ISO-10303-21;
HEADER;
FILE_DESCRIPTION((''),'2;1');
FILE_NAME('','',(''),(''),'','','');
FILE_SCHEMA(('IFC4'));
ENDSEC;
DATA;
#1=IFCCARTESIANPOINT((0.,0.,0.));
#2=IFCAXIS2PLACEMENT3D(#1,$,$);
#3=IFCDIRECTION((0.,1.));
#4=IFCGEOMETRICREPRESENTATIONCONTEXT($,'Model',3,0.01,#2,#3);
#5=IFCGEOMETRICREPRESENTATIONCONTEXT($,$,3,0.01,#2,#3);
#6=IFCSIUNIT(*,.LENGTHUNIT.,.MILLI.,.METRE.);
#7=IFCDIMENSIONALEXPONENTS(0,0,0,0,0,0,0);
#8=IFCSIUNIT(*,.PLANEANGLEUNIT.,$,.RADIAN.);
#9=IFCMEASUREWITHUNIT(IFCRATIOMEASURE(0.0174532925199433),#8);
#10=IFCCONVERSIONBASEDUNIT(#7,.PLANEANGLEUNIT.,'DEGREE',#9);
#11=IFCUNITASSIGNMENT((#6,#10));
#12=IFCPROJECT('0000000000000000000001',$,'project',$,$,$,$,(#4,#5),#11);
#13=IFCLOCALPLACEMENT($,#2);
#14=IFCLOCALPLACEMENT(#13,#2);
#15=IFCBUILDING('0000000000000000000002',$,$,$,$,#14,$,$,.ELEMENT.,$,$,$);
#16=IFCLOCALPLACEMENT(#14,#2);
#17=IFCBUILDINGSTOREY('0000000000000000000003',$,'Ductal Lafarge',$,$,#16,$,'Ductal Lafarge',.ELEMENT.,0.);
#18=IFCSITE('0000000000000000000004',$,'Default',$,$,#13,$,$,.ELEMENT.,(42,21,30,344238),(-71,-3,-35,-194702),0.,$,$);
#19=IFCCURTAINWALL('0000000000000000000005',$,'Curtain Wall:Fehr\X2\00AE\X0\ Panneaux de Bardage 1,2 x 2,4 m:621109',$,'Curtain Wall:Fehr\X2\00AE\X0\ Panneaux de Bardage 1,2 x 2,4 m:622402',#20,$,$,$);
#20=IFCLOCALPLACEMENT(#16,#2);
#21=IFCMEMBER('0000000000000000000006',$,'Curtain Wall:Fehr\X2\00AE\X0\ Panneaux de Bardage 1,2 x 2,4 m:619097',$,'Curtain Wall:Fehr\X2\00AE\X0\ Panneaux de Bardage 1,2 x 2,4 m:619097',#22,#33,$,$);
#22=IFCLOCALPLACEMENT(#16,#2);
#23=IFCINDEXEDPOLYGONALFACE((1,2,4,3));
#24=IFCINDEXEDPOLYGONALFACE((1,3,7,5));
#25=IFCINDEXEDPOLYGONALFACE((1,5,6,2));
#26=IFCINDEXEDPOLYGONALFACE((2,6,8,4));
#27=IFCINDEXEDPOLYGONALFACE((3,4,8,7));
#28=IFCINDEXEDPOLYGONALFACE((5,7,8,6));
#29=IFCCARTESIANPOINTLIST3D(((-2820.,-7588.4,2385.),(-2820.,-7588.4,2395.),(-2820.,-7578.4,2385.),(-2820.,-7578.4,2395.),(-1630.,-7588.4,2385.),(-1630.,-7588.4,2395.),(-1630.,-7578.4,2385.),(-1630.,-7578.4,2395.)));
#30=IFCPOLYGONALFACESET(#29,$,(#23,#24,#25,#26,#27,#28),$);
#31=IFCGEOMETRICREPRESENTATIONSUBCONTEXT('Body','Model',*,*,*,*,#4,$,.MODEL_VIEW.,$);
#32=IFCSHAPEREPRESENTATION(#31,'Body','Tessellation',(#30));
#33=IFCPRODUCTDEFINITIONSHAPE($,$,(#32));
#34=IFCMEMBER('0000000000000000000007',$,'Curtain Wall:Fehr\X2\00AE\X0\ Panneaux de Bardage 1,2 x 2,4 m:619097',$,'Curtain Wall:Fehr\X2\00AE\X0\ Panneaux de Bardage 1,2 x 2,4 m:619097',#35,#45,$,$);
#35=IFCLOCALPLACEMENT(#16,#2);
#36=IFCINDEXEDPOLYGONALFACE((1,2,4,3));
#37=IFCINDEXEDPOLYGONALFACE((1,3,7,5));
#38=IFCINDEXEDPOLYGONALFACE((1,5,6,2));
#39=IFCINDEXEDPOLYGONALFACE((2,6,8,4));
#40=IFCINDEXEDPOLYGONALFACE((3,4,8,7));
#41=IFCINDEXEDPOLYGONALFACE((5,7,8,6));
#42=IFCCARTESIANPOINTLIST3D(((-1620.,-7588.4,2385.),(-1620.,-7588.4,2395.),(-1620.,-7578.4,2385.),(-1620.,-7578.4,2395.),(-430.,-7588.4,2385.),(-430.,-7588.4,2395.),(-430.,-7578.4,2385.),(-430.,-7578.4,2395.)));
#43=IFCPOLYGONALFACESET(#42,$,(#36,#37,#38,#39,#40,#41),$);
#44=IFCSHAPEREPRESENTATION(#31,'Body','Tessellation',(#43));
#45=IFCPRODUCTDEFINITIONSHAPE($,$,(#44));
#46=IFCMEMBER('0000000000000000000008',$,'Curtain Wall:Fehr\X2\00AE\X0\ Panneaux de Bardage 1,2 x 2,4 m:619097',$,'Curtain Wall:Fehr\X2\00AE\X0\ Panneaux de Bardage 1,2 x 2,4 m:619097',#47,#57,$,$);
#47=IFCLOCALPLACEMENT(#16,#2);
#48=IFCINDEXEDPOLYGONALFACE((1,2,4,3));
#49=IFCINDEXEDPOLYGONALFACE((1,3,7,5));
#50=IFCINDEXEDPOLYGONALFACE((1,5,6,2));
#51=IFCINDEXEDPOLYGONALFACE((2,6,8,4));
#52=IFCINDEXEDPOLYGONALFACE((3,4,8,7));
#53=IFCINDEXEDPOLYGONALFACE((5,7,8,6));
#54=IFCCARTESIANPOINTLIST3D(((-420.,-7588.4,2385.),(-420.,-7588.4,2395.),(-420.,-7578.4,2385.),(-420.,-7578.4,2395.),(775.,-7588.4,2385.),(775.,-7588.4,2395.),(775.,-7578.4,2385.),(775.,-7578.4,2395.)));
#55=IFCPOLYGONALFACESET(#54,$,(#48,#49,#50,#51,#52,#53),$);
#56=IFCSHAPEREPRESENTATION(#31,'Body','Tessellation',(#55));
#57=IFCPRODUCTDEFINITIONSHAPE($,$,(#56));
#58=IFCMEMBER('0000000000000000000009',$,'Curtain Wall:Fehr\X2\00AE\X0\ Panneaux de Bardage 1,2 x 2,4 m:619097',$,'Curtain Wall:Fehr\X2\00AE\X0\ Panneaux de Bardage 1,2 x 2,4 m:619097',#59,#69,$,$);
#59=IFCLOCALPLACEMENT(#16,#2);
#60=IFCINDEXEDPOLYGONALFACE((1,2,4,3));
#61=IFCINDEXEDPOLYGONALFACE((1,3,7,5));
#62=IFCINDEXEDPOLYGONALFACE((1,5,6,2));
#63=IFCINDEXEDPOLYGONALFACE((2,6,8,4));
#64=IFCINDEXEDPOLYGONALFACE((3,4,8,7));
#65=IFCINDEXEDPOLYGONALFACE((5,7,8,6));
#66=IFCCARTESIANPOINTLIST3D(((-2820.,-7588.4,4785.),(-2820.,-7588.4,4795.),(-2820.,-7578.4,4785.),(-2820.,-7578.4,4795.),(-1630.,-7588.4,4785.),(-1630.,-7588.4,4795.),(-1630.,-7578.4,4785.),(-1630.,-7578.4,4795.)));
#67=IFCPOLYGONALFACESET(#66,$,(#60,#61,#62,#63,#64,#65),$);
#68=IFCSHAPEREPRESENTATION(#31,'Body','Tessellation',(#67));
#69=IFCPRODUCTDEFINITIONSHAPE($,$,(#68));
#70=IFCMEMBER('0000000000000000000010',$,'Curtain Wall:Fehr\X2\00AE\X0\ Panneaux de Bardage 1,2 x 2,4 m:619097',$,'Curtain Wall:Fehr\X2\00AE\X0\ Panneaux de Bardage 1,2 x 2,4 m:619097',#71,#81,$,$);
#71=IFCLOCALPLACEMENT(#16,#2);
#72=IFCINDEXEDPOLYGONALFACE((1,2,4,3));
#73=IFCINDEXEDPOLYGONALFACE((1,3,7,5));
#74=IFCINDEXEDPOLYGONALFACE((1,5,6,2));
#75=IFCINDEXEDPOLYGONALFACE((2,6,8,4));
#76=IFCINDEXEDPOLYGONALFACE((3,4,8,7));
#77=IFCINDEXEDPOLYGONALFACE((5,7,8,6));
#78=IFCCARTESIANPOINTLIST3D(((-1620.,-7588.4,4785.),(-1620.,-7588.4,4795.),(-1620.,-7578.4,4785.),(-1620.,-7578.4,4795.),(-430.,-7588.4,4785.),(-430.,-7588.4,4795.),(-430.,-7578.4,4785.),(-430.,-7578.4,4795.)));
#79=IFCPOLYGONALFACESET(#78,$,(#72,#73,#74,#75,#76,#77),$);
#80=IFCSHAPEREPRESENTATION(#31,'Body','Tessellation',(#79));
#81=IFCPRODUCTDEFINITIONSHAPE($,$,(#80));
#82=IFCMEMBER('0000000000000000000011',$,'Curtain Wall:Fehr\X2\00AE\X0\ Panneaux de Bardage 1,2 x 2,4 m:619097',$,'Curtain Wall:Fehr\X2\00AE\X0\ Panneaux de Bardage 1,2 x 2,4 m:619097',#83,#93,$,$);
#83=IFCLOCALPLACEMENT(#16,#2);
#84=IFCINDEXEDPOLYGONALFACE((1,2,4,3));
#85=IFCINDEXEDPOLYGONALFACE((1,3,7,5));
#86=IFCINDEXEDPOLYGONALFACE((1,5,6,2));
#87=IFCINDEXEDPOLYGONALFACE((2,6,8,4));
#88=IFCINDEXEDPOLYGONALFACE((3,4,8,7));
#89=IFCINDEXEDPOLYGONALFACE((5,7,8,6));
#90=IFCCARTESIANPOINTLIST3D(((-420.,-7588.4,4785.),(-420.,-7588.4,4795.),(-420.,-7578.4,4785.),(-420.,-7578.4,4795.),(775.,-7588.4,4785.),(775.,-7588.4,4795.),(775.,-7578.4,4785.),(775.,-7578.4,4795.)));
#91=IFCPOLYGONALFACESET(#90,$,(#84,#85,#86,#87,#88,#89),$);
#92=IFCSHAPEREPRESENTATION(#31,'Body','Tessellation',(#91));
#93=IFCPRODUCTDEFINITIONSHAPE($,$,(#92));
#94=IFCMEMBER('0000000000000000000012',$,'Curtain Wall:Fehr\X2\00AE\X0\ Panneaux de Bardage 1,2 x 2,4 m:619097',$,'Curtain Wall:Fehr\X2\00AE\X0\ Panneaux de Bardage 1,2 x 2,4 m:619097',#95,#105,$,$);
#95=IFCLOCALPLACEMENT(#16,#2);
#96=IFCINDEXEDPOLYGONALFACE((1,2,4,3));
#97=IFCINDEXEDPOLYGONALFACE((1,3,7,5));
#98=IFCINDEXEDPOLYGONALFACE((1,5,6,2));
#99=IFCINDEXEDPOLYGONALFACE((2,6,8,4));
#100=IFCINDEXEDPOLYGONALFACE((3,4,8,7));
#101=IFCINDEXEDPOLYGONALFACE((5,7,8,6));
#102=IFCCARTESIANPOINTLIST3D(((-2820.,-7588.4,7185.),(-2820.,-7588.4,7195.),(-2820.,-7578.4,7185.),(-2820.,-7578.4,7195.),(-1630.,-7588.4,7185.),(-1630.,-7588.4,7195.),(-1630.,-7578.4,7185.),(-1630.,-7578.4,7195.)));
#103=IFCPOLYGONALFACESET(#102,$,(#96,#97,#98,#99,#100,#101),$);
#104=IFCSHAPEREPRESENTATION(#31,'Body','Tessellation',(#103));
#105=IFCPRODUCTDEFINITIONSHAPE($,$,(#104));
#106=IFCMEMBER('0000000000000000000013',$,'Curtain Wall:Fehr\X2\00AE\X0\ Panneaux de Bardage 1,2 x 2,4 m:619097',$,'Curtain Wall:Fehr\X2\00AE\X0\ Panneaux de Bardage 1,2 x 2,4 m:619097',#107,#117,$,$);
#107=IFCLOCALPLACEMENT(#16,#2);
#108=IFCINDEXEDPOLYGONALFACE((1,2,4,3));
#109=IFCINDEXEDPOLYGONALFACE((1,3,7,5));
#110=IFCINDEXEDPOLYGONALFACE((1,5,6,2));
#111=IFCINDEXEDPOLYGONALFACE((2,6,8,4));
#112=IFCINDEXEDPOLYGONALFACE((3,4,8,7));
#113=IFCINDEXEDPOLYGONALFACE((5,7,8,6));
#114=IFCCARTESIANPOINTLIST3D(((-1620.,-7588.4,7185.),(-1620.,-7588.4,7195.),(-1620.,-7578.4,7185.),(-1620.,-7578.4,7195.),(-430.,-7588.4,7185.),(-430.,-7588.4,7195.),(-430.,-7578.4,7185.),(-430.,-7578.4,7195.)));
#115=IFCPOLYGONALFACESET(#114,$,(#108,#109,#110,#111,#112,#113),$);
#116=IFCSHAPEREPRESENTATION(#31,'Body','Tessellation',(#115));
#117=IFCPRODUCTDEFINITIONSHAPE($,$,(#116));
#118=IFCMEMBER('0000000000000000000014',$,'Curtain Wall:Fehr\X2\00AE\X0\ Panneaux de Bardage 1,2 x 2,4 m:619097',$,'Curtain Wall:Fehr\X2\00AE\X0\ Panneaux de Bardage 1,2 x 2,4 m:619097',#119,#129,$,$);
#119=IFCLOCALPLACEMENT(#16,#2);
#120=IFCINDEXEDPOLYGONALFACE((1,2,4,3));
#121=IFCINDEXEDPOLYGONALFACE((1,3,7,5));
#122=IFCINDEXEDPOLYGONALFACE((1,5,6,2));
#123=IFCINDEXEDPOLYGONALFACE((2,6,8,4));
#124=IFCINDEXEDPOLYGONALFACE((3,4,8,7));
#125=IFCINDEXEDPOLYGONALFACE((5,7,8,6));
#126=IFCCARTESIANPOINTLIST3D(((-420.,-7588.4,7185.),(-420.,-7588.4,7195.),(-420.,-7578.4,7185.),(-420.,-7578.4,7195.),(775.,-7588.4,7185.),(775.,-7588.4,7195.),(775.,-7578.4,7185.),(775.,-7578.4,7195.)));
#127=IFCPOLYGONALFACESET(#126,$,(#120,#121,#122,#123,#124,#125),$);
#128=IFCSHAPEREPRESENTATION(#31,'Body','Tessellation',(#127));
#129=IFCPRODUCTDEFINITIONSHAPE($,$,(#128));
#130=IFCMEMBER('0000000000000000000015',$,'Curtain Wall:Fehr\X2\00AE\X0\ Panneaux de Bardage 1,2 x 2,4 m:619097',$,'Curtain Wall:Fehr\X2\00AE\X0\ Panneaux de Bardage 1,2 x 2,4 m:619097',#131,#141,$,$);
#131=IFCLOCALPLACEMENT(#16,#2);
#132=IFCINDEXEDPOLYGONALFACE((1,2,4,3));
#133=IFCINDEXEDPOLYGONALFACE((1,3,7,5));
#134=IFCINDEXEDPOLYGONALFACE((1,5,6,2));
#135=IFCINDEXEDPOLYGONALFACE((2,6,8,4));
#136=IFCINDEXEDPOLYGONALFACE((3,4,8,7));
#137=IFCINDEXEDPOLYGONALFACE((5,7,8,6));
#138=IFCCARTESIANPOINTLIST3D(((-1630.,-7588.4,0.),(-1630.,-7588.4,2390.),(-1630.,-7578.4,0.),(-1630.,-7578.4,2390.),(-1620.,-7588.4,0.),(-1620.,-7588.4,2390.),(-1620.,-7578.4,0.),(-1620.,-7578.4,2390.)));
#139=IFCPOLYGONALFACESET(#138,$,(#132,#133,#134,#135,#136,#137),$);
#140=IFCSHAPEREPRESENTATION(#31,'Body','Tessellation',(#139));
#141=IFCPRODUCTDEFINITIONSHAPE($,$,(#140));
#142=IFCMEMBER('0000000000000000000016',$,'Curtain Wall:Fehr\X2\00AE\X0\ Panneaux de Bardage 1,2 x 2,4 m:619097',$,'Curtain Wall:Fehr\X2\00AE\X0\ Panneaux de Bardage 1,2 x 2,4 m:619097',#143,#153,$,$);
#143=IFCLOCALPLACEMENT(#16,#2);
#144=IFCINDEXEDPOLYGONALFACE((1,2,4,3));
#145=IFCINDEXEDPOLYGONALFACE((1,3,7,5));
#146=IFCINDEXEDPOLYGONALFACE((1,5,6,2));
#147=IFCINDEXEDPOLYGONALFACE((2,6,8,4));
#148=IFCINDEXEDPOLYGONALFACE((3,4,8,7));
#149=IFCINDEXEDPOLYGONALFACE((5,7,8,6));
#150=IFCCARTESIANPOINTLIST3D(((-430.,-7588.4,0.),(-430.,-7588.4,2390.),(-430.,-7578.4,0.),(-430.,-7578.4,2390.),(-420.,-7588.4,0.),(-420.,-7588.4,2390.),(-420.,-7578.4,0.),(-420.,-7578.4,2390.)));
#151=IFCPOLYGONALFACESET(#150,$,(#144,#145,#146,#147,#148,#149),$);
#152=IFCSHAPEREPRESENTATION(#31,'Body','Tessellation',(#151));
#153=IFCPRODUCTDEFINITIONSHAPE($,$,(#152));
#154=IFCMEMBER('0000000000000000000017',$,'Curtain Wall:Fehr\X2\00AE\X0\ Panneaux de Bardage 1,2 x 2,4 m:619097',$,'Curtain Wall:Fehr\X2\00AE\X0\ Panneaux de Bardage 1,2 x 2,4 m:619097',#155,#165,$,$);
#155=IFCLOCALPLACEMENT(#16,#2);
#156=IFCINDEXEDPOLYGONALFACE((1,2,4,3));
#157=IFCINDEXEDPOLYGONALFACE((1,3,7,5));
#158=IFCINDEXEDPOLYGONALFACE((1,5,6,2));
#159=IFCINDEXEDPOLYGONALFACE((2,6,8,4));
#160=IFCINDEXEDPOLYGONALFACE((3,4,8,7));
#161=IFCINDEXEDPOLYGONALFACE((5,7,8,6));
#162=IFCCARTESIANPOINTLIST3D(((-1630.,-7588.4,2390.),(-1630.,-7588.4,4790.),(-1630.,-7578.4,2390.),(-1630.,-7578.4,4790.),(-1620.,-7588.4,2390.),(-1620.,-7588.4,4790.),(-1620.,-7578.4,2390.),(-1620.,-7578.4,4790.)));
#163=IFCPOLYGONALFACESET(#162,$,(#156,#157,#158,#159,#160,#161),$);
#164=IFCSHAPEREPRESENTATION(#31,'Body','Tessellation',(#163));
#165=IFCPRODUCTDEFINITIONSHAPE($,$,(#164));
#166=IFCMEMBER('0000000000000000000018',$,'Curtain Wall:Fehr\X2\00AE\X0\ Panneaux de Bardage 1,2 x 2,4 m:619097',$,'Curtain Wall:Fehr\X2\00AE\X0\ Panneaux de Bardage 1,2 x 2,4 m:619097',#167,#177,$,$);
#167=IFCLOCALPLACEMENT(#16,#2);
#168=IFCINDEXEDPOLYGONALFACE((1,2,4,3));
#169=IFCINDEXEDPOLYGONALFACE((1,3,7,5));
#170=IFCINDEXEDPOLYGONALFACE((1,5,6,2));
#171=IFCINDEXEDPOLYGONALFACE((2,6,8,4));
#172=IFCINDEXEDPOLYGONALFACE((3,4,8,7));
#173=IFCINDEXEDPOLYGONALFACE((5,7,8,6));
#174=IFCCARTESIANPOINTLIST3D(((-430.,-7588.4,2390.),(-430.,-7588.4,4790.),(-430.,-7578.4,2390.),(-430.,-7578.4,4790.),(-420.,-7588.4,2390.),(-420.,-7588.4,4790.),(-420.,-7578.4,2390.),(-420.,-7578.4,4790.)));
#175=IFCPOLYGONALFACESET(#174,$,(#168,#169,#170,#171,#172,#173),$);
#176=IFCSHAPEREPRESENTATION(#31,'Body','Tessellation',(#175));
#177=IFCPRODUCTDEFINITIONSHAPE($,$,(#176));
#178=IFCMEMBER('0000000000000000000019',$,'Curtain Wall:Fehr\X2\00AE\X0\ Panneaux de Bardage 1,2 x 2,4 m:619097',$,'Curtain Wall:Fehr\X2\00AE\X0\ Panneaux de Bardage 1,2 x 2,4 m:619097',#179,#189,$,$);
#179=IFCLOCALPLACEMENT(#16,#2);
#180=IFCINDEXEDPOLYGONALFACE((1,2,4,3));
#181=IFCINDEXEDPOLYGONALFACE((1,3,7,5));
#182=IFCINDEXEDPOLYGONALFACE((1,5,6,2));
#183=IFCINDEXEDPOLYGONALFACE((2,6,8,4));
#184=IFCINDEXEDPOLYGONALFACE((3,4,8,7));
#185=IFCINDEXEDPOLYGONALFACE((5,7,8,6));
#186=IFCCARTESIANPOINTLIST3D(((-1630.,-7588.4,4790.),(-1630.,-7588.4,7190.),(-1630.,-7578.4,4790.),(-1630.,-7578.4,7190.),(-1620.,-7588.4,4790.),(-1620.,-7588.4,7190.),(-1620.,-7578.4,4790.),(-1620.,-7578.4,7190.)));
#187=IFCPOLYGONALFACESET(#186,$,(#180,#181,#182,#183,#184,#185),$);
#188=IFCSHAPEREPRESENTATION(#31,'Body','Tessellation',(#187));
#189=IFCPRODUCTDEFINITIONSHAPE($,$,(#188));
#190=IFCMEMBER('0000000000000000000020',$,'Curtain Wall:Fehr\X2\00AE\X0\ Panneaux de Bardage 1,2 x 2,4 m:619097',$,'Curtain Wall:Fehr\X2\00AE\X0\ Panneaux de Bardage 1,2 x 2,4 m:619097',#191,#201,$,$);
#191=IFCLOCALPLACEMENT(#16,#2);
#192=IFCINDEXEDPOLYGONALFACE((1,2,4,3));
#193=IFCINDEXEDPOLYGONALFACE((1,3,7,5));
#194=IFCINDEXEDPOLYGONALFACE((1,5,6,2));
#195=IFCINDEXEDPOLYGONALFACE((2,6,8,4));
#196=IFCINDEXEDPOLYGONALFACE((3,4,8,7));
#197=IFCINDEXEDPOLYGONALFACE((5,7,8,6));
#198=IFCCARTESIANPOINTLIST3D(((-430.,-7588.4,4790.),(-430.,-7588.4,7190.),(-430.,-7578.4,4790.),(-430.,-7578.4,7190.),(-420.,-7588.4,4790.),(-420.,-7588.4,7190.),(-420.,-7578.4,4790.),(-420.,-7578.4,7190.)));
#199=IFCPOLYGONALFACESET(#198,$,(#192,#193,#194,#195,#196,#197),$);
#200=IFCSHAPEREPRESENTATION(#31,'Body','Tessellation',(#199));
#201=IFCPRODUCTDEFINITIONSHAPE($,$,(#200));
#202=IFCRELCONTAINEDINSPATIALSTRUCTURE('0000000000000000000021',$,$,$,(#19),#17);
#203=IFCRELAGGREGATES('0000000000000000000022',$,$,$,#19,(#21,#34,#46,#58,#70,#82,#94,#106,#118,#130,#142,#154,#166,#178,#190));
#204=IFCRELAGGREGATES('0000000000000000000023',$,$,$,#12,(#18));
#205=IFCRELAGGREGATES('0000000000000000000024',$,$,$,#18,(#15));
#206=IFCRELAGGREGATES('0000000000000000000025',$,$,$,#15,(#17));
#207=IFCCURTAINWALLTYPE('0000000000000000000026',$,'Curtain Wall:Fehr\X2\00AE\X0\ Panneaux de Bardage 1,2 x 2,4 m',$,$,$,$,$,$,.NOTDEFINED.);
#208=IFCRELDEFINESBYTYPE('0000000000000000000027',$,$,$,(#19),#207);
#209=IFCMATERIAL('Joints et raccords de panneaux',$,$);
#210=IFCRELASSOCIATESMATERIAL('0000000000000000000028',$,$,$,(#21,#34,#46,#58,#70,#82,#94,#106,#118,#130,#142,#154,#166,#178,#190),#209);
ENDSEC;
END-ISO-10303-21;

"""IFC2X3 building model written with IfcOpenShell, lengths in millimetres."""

from ifc_helpers import new_model, entity, si_unit, converted_unit, direction, frame, frame_2d, origin, origin_2d_with_axis, place, context, subcontext, project, spatial, rectangle, extrude, material, type_object, element, aggregate, save


model = new_model("IFC2X3")

# Units and contexts
model_context = context("Model", 3, precision=0.01, world=origin(), true_north=direction((0.0, 1.0)))
context_of_model = context(None, 3, precision=0.01, world=origin(), true_north=direction((0.0, 1.0)))
body_context = subcontext(model_context, "Body", "Model", "MODEL_VIEW")
ifc_project = project(units=[si_unit("LENGTHUNIT", "METRE", prefix="MILLI"), converted_unit("PLANEANGLEUNIT", "DEGREE", entity("IfcRatioMeasure", 0.0174532925199433), si_unit("PLANEANGLEUNIT", "RADIAN"), dimensions=[0, 0, 0, 0, 0, 0, 0])], contexts=[model_context, context_of_model])

# Site, building, storey
site_placement = place(None, origin())
site = spatial("IfcSite", under=ifc_project, at=site_placement, Name="Default", CompositionType="ELEMENT", RefLatitude=(42, 21, 30, 344238), RefLongitude=(-71, -3, -35, -194702), RefElevation=0.0)
building_placement = place(site_placement, origin())
building = spatial("IfcBuilding", under=site, at=building_placement, CompositionType="ELEMENT")
storey_placement = place(building_placement, origin())
storey = spatial("IfcBuildingStorey", under=building, at=storey_placement, Name="Ductal Lafarge", LongName="Ductal Lafarge", CompositionType="ELEMENT", Elevation=0.0)

# Curtain wall, members
curtain_wall_type_1 = type_object("IfcCurtainWallType", Name="Curtain Wall:Fehr® Panneaux de Bardage 1,2 x 2,4 m", PredefinedType="NOTDEFINED")
curtain_wall_1_placement = place(storey_placement, origin())
curtain_wall_1 = element("IfcCurtainWall", 1, at=curtain_wall_1_placement, inside=storey, type_object=curtain_wall_type_1, Name="Curtain Wall:Fehr® Panneaux de Bardage 1,2 x 2,4 m:621109", ObjectType="Curtain Wall:Fehr® Panneaux de Bardage 1,2 x 2,4 m:622402")
ifc_material_1 = material(Name="Joints et raccords de panneaux")
member_1_placement = place(curtain_wall_1_placement, frame((-2820.0, -7588.4, 2385.0)))
member_1 = element("IfcMember", 2, at=member_1_placement, material=ifc_material_1, Name="Curtain Wall:Fehr® Panneaux de Bardage 1,2 x 2,4 m:619097", ObjectType="Curtain Wall:Fehr® Panneaux de Bardage 1,2 x 2,4 m:619097", context=body_context, shape_type="SweptSolid", body=[
    extrude(rectangle(XDim=1190.0, YDim=10.0, at=frame_2d((0.0, 0.0), x_axis=(1.0, 0.0))), frame((595.0, 5.0, 0.0), z_axis=(0.0, 0.0, 1.0), x_axis=(-1.0, 0.0, 0.0)), (0.0, 0.0, 1.0), 10.0),
])
member_2_placement = place(curtain_wall_1_placement, frame((-1620.0, -7588.4, 2385.0)))
member_2 = element("IfcMember", 3, at=member_2_placement, material=ifc_material_1, Name="Curtain Wall:Fehr® Panneaux de Bardage 1,2 x 2,4 m:619097", ObjectType="Curtain Wall:Fehr® Panneaux de Bardage 1,2 x 2,4 m:619097", context=body_context, shape_type="SweptSolid", body=[
    extrude(rectangle(XDim=1190.0, YDim=10.0, at=frame_2d((0.0, 0.0), x_axis=(1.0, 0.0))), frame((595.0, 5.0, 0.0), z_axis=(0.0, 0.0, 1.0), x_axis=(-1.0, 0.0, 0.0)), (0.0, 0.0, 1.0), 10.0),
])
member_3_placement = place(curtain_wall_1_placement, frame((-420.0, -7588.4, 2385.0)))
member_3 = element("IfcMember", 4, at=member_3_placement, material=ifc_material_1, Name="Curtain Wall:Fehr® Panneaux de Bardage 1,2 x 2,4 m:619097", ObjectType="Curtain Wall:Fehr® Panneaux de Bardage 1,2 x 2,4 m:619097", context=body_context, shape_type="SweptSolid", body=[
    extrude(rectangle(XDim=1195.0, YDim=10.0, at=frame_2d((0.0, 0.0), x_axis=(1.0, 0.0))), frame((597.5, 5.0, 0.0), z_axis=(0.0, 0.0, 1.0), x_axis=(-1.0, 0.0, 0.0)), (0.0, 0.0, 1.0), 10.0),
])
member_4_placement = place(curtain_wall_1_placement, frame((-2820.0, -7588.4, 4785.0)))
member_4 = element("IfcMember", 5, at=member_4_placement, material=ifc_material_1, Name="Curtain Wall:Fehr® Panneaux de Bardage 1,2 x 2,4 m:619097", ObjectType="Curtain Wall:Fehr® Panneaux de Bardage 1,2 x 2,4 m:619097", context=body_context, shape_type="SweptSolid", body=[
    extrude(rectangle(XDim=1190.0, YDim=10.0, at=frame_2d((0.0, 0.0), x_axis=(1.0, 0.0))), frame((595.0, 5.0, 0.0), z_axis=(0.0, 0.0, 1.0), x_axis=(-1.0, 0.0, 0.0)), (0.0, 0.0, 1.0), 10.0),
])
member_5_placement = place(curtain_wall_1_placement, frame((-1620.0, -7588.4, 4785.0)))
member_5 = element("IfcMember", 6, at=member_5_placement, material=ifc_material_1, Name="Curtain Wall:Fehr® Panneaux de Bardage 1,2 x 2,4 m:619097", ObjectType="Curtain Wall:Fehr® Panneaux de Bardage 1,2 x 2,4 m:619097", context=body_context, shape_type="SweptSolid", body=[
    extrude(rectangle(XDim=1190.0, YDim=10.0, at=frame_2d((0.0, 0.0), x_axis=(1.0, 0.0))), frame((595.0, 5.0, 0.0), z_axis=(0.0, 0.0, 1.0), x_axis=(-1.0, 0.0, 0.0)), (0.0, 0.0, 1.0), 10.0),
])
member_6_placement = place(curtain_wall_1_placement, frame((-420.0, -7588.4, 4785.0)))
member_6 = element("IfcMember", 7, at=member_6_placement, material=ifc_material_1, Name="Curtain Wall:Fehr® Panneaux de Bardage 1,2 x 2,4 m:619097", ObjectType="Curtain Wall:Fehr® Panneaux de Bardage 1,2 x 2,4 m:619097", context=body_context, shape_type="SweptSolid", body=[
    extrude(rectangle(XDim=1195.0, YDim=10.0, at=frame_2d((0.0, 0.0), x_axis=(1.0, 0.0))), frame((597.5, 5.0, 0.0), z_axis=(0.0, 0.0, 1.0), x_axis=(-1.0, 0.0, 0.0)), (0.0, 0.0, 1.0), 10.0),
])
member_7_placement = place(curtain_wall_1_placement, frame((-2820.0, -7588.4, 7185.0)))
member_7 = element("IfcMember", 8, at=member_7_placement, material=ifc_material_1, Name="Curtain Wall:Fehr® Panneaux de Bardage 1,2 x 2,4 m:619097", ObjectType="Curtain Wall:Fehr® Panneaux de Bardage 1,2 x 2,4 m:619097", context=body_context, shape_type="SweptSolid", body=[
    extrude(rectangle(XDim=1190.0, YDim=10.0, at=frame_2d((0.0, 0.0), x_axis=(1.0, 0.0))), frame((595.0, 5.0, 0.0), z_axis=(0.0, 0.0, 1.0), x_axis=(-1.0, 0.0, 0.0)), (0.0, 0.0, 1.0), 10.0),
])
member_8_placement = place(curtain_wall_1_placement, frame((-1620.0, -7588.4, 7185.0)))
member_8 = element("IfcMember", 9, at=member_8_placement, material=ifc_material_1, Name="Curtain Wall:Fehr® Panneaux de Bardage 1,2 x 2,4 m:619097", ObjectType="Curtain Wall:Fehr® Panneaux de Bardage 1,2 x 2,4 m:619097", context=body_context, shape_type="SweptSolid", body=[
    extrude(rectangle(XDim=1190.0, YDim=10.0, at=frame_2d((0.0, 0.0), x_axis=(1.0, 0.0))), frame((595.0, 5.0, 0.0), z_axis=(0.0, 0.0, 1.0), x_axis=(-1.0, 0.0, 0.0)), (0.0, 0.0, 1.0), 10.0),
])
member_9_placement = place(curtain_wall_1_placement, frame((-420.0, -7588.4, 7185.0)))
member_9 = element("IfcMember", 10, at=member_9_placement, material=ifc_material_1, Name="Curtain Wall:Fehr® Panneaux de Bardage 1,2 x 2,4 m:619097", ObjectType="Curtain Wall:Fehr® Panneaux de Bardage 1,2 x 2,4 m:619097", context=body_context, shape_type="SweptSolid", body=[
    extrude(rectangle(XDim=1195.0, YDim=10.0, at=frame_2d((0.0, 0.0), x_axis=(1.0, 0.0))), frame((597.5, 5.0, 0.0), z_axis=(0.0, 0.0, 1.0), x_axis=(-1.0, 0.0, 0.0)), (0.0, 0.0, 1.0), 10.0),
])
member_10_placement = place(curtain_wall_1_placement, frame((-1630.0, -7588.4, 0.0)))
member_10 = element("IfcMember", 11, at=member_10_placement, material=ifc_material_1, Name="Curtain Wall:Fehr® Panneaux de Bardage 1,2 x 2,4 m:619097", ObjectType="Curtain Wall:Fehr® Panneaux de Bardage 1,2 x 2,4 m:619097", context=body_context, shape_type="SweptSolid", body=[
    extrude(rectangle(XDim=10.0, YDim=10.0, at=origin_2d_with_axis()), frame((5.0, 5.0, 0.0), z_axis=(0.0, 0.0, 1.0), x_axis=(0.0, 1.0, 0.0)), (0.0, 0.0, 1.0), 2390.0),
])
member_11_placement = place(curtain_wall_1_placement, frame((-430.0, -7588.4, 0.0)))
member_11 = element("IfcMember", 12, at=member_11_placement, material=ifc_material_1, Name="Curtain Wall:Fehr® Panneaux de Bardage 1,2 x 2,4 m:619097", ObjectType="Curtain Wall:Fehr® Panneaux de Bardage 1,2 x 2,4 m:619097", context=body_context, shape_type="SweptSolid", body=[
    extrude(rectangle(XDim=10.0, YDim=10.0, at=origin_2d_with_axis()), frame((5.0, 5.0, 0.0), z_axis=(0.0, 0.0, 1.0), x_axis=(0.0, 1.0, 0.0)), (0.0, 0.0, 1.0), 2390.0),
])
member_12_placement = place(curtain_wall_1_placement, frame((-1630.0, -7588.4, 2390.0)))
member_12 = element("IfcMember", 13, at=member_12_placement, material=ifc_material_1, Name="Curtain Wall:Fehr® Panneaux de Bardage 1,2 x 2,4 m:619097", ObjectType="Curtain Wall:Fehr® Panneaux de Bardage 1,2 x 2,4 m:619097", context=body_context, shape_type="SweptSolid", body=[
    extrude(rectangle(XDim=10.0, YDim=10.0, at=origin_2d_with_axis()), frame((5.0, 5.0, 0.0), z_axis=(0.0, 0.0, 1.0), x_axis=(0.0, 1.0, 0.0)), (0.0, 0.0, 1.0), 2400.0),
])
member_13_placement = place(curtain_wall_1_placement, frame((-430.0, -7588.4, 2390.0)))
member_13 = element("IfcMember", 14, at=member_13_placement, material=ifc_material_1, Name="Curtain Wall:Fehr® Panneaux de Bardage 1,2 x 2,4 m:619097", ObjectType="Curtain Wall:Fehr® Panneaux de Bardage 1,2 x 2,4 m:619097", context=body_context, shape_type="SweptSolid", body=[
    extrude(rectangle(XDim=10.0, YDim=10.0, at=origin_2d_with_axis()), frame((5.0, 5.0, 0.0), z_axis=(0.0, 0.0, 1.0), x_axis=(0.0, 1.0, 0.0)), (0.0, 0.0, 1.0), 2400.0),
])
member_14_placement = place(curtain_wall_1_placement, frame((-1630.0, -7588.4, 4790.0)))
member_14 = element("IfcMember", 15, at=member_14_placement, material=ifc_material_1, Name="Curtain Wall:Fehr® Panneaux de Bardage 1,2 x 2,4 m:619097", ObjectType="Curtain Wall:Fehr® Panneaux de Bardage 1,2 x 2,4 m:619097", context=body_context, shape_type="SweptSolid", body=[
    extrude(rectangle(XDim=10.0, YDim=10.0, at=origin_2d_with_axis()), frame((5.0, 5.0, 0.0), z_axis=(0.0, 0.0, 1.0), x_axis=(0.0, 1.0, 0.0)), (0.0, 0.0, 1.0), 2400.0),
])
member_15_placement = place(curtain_wall_1_placement, frame((-430.0, -7588.4, 4790.0)))
member_15 = element("IfcMember", 16, at=member_15_placement, material=ifc_material_1, Name="Curtain Wall:Fehr® Panneaux de Bardage 1,2 x 2,4 m:619097", ObjectType="Curtain Wall:Fehr® Panneaux de Bardage 1,2 x 2,4 m:619097", context=body_context, shape_type="SweptSolid", body=[
    extrude(rectangle(XDim=10.0, YDim=10.0, at=origin_2d_with_axis()), frame((5.0, 5.0, 0.0), z_axis=(0.0, 0.0, 1.0), x_axis=(0.0, 1.0, 0.0)), (0.0, 0.0, 1.0), 2400.0),
])
aggregate(curtain_wall_1, [member_1, member_2, member_3, member_4, member_5, member_6, member_7, member_8, member_9, member_10, member_11, member_12, member_13, member_14, member_15])

save(model, "model.ifc")
